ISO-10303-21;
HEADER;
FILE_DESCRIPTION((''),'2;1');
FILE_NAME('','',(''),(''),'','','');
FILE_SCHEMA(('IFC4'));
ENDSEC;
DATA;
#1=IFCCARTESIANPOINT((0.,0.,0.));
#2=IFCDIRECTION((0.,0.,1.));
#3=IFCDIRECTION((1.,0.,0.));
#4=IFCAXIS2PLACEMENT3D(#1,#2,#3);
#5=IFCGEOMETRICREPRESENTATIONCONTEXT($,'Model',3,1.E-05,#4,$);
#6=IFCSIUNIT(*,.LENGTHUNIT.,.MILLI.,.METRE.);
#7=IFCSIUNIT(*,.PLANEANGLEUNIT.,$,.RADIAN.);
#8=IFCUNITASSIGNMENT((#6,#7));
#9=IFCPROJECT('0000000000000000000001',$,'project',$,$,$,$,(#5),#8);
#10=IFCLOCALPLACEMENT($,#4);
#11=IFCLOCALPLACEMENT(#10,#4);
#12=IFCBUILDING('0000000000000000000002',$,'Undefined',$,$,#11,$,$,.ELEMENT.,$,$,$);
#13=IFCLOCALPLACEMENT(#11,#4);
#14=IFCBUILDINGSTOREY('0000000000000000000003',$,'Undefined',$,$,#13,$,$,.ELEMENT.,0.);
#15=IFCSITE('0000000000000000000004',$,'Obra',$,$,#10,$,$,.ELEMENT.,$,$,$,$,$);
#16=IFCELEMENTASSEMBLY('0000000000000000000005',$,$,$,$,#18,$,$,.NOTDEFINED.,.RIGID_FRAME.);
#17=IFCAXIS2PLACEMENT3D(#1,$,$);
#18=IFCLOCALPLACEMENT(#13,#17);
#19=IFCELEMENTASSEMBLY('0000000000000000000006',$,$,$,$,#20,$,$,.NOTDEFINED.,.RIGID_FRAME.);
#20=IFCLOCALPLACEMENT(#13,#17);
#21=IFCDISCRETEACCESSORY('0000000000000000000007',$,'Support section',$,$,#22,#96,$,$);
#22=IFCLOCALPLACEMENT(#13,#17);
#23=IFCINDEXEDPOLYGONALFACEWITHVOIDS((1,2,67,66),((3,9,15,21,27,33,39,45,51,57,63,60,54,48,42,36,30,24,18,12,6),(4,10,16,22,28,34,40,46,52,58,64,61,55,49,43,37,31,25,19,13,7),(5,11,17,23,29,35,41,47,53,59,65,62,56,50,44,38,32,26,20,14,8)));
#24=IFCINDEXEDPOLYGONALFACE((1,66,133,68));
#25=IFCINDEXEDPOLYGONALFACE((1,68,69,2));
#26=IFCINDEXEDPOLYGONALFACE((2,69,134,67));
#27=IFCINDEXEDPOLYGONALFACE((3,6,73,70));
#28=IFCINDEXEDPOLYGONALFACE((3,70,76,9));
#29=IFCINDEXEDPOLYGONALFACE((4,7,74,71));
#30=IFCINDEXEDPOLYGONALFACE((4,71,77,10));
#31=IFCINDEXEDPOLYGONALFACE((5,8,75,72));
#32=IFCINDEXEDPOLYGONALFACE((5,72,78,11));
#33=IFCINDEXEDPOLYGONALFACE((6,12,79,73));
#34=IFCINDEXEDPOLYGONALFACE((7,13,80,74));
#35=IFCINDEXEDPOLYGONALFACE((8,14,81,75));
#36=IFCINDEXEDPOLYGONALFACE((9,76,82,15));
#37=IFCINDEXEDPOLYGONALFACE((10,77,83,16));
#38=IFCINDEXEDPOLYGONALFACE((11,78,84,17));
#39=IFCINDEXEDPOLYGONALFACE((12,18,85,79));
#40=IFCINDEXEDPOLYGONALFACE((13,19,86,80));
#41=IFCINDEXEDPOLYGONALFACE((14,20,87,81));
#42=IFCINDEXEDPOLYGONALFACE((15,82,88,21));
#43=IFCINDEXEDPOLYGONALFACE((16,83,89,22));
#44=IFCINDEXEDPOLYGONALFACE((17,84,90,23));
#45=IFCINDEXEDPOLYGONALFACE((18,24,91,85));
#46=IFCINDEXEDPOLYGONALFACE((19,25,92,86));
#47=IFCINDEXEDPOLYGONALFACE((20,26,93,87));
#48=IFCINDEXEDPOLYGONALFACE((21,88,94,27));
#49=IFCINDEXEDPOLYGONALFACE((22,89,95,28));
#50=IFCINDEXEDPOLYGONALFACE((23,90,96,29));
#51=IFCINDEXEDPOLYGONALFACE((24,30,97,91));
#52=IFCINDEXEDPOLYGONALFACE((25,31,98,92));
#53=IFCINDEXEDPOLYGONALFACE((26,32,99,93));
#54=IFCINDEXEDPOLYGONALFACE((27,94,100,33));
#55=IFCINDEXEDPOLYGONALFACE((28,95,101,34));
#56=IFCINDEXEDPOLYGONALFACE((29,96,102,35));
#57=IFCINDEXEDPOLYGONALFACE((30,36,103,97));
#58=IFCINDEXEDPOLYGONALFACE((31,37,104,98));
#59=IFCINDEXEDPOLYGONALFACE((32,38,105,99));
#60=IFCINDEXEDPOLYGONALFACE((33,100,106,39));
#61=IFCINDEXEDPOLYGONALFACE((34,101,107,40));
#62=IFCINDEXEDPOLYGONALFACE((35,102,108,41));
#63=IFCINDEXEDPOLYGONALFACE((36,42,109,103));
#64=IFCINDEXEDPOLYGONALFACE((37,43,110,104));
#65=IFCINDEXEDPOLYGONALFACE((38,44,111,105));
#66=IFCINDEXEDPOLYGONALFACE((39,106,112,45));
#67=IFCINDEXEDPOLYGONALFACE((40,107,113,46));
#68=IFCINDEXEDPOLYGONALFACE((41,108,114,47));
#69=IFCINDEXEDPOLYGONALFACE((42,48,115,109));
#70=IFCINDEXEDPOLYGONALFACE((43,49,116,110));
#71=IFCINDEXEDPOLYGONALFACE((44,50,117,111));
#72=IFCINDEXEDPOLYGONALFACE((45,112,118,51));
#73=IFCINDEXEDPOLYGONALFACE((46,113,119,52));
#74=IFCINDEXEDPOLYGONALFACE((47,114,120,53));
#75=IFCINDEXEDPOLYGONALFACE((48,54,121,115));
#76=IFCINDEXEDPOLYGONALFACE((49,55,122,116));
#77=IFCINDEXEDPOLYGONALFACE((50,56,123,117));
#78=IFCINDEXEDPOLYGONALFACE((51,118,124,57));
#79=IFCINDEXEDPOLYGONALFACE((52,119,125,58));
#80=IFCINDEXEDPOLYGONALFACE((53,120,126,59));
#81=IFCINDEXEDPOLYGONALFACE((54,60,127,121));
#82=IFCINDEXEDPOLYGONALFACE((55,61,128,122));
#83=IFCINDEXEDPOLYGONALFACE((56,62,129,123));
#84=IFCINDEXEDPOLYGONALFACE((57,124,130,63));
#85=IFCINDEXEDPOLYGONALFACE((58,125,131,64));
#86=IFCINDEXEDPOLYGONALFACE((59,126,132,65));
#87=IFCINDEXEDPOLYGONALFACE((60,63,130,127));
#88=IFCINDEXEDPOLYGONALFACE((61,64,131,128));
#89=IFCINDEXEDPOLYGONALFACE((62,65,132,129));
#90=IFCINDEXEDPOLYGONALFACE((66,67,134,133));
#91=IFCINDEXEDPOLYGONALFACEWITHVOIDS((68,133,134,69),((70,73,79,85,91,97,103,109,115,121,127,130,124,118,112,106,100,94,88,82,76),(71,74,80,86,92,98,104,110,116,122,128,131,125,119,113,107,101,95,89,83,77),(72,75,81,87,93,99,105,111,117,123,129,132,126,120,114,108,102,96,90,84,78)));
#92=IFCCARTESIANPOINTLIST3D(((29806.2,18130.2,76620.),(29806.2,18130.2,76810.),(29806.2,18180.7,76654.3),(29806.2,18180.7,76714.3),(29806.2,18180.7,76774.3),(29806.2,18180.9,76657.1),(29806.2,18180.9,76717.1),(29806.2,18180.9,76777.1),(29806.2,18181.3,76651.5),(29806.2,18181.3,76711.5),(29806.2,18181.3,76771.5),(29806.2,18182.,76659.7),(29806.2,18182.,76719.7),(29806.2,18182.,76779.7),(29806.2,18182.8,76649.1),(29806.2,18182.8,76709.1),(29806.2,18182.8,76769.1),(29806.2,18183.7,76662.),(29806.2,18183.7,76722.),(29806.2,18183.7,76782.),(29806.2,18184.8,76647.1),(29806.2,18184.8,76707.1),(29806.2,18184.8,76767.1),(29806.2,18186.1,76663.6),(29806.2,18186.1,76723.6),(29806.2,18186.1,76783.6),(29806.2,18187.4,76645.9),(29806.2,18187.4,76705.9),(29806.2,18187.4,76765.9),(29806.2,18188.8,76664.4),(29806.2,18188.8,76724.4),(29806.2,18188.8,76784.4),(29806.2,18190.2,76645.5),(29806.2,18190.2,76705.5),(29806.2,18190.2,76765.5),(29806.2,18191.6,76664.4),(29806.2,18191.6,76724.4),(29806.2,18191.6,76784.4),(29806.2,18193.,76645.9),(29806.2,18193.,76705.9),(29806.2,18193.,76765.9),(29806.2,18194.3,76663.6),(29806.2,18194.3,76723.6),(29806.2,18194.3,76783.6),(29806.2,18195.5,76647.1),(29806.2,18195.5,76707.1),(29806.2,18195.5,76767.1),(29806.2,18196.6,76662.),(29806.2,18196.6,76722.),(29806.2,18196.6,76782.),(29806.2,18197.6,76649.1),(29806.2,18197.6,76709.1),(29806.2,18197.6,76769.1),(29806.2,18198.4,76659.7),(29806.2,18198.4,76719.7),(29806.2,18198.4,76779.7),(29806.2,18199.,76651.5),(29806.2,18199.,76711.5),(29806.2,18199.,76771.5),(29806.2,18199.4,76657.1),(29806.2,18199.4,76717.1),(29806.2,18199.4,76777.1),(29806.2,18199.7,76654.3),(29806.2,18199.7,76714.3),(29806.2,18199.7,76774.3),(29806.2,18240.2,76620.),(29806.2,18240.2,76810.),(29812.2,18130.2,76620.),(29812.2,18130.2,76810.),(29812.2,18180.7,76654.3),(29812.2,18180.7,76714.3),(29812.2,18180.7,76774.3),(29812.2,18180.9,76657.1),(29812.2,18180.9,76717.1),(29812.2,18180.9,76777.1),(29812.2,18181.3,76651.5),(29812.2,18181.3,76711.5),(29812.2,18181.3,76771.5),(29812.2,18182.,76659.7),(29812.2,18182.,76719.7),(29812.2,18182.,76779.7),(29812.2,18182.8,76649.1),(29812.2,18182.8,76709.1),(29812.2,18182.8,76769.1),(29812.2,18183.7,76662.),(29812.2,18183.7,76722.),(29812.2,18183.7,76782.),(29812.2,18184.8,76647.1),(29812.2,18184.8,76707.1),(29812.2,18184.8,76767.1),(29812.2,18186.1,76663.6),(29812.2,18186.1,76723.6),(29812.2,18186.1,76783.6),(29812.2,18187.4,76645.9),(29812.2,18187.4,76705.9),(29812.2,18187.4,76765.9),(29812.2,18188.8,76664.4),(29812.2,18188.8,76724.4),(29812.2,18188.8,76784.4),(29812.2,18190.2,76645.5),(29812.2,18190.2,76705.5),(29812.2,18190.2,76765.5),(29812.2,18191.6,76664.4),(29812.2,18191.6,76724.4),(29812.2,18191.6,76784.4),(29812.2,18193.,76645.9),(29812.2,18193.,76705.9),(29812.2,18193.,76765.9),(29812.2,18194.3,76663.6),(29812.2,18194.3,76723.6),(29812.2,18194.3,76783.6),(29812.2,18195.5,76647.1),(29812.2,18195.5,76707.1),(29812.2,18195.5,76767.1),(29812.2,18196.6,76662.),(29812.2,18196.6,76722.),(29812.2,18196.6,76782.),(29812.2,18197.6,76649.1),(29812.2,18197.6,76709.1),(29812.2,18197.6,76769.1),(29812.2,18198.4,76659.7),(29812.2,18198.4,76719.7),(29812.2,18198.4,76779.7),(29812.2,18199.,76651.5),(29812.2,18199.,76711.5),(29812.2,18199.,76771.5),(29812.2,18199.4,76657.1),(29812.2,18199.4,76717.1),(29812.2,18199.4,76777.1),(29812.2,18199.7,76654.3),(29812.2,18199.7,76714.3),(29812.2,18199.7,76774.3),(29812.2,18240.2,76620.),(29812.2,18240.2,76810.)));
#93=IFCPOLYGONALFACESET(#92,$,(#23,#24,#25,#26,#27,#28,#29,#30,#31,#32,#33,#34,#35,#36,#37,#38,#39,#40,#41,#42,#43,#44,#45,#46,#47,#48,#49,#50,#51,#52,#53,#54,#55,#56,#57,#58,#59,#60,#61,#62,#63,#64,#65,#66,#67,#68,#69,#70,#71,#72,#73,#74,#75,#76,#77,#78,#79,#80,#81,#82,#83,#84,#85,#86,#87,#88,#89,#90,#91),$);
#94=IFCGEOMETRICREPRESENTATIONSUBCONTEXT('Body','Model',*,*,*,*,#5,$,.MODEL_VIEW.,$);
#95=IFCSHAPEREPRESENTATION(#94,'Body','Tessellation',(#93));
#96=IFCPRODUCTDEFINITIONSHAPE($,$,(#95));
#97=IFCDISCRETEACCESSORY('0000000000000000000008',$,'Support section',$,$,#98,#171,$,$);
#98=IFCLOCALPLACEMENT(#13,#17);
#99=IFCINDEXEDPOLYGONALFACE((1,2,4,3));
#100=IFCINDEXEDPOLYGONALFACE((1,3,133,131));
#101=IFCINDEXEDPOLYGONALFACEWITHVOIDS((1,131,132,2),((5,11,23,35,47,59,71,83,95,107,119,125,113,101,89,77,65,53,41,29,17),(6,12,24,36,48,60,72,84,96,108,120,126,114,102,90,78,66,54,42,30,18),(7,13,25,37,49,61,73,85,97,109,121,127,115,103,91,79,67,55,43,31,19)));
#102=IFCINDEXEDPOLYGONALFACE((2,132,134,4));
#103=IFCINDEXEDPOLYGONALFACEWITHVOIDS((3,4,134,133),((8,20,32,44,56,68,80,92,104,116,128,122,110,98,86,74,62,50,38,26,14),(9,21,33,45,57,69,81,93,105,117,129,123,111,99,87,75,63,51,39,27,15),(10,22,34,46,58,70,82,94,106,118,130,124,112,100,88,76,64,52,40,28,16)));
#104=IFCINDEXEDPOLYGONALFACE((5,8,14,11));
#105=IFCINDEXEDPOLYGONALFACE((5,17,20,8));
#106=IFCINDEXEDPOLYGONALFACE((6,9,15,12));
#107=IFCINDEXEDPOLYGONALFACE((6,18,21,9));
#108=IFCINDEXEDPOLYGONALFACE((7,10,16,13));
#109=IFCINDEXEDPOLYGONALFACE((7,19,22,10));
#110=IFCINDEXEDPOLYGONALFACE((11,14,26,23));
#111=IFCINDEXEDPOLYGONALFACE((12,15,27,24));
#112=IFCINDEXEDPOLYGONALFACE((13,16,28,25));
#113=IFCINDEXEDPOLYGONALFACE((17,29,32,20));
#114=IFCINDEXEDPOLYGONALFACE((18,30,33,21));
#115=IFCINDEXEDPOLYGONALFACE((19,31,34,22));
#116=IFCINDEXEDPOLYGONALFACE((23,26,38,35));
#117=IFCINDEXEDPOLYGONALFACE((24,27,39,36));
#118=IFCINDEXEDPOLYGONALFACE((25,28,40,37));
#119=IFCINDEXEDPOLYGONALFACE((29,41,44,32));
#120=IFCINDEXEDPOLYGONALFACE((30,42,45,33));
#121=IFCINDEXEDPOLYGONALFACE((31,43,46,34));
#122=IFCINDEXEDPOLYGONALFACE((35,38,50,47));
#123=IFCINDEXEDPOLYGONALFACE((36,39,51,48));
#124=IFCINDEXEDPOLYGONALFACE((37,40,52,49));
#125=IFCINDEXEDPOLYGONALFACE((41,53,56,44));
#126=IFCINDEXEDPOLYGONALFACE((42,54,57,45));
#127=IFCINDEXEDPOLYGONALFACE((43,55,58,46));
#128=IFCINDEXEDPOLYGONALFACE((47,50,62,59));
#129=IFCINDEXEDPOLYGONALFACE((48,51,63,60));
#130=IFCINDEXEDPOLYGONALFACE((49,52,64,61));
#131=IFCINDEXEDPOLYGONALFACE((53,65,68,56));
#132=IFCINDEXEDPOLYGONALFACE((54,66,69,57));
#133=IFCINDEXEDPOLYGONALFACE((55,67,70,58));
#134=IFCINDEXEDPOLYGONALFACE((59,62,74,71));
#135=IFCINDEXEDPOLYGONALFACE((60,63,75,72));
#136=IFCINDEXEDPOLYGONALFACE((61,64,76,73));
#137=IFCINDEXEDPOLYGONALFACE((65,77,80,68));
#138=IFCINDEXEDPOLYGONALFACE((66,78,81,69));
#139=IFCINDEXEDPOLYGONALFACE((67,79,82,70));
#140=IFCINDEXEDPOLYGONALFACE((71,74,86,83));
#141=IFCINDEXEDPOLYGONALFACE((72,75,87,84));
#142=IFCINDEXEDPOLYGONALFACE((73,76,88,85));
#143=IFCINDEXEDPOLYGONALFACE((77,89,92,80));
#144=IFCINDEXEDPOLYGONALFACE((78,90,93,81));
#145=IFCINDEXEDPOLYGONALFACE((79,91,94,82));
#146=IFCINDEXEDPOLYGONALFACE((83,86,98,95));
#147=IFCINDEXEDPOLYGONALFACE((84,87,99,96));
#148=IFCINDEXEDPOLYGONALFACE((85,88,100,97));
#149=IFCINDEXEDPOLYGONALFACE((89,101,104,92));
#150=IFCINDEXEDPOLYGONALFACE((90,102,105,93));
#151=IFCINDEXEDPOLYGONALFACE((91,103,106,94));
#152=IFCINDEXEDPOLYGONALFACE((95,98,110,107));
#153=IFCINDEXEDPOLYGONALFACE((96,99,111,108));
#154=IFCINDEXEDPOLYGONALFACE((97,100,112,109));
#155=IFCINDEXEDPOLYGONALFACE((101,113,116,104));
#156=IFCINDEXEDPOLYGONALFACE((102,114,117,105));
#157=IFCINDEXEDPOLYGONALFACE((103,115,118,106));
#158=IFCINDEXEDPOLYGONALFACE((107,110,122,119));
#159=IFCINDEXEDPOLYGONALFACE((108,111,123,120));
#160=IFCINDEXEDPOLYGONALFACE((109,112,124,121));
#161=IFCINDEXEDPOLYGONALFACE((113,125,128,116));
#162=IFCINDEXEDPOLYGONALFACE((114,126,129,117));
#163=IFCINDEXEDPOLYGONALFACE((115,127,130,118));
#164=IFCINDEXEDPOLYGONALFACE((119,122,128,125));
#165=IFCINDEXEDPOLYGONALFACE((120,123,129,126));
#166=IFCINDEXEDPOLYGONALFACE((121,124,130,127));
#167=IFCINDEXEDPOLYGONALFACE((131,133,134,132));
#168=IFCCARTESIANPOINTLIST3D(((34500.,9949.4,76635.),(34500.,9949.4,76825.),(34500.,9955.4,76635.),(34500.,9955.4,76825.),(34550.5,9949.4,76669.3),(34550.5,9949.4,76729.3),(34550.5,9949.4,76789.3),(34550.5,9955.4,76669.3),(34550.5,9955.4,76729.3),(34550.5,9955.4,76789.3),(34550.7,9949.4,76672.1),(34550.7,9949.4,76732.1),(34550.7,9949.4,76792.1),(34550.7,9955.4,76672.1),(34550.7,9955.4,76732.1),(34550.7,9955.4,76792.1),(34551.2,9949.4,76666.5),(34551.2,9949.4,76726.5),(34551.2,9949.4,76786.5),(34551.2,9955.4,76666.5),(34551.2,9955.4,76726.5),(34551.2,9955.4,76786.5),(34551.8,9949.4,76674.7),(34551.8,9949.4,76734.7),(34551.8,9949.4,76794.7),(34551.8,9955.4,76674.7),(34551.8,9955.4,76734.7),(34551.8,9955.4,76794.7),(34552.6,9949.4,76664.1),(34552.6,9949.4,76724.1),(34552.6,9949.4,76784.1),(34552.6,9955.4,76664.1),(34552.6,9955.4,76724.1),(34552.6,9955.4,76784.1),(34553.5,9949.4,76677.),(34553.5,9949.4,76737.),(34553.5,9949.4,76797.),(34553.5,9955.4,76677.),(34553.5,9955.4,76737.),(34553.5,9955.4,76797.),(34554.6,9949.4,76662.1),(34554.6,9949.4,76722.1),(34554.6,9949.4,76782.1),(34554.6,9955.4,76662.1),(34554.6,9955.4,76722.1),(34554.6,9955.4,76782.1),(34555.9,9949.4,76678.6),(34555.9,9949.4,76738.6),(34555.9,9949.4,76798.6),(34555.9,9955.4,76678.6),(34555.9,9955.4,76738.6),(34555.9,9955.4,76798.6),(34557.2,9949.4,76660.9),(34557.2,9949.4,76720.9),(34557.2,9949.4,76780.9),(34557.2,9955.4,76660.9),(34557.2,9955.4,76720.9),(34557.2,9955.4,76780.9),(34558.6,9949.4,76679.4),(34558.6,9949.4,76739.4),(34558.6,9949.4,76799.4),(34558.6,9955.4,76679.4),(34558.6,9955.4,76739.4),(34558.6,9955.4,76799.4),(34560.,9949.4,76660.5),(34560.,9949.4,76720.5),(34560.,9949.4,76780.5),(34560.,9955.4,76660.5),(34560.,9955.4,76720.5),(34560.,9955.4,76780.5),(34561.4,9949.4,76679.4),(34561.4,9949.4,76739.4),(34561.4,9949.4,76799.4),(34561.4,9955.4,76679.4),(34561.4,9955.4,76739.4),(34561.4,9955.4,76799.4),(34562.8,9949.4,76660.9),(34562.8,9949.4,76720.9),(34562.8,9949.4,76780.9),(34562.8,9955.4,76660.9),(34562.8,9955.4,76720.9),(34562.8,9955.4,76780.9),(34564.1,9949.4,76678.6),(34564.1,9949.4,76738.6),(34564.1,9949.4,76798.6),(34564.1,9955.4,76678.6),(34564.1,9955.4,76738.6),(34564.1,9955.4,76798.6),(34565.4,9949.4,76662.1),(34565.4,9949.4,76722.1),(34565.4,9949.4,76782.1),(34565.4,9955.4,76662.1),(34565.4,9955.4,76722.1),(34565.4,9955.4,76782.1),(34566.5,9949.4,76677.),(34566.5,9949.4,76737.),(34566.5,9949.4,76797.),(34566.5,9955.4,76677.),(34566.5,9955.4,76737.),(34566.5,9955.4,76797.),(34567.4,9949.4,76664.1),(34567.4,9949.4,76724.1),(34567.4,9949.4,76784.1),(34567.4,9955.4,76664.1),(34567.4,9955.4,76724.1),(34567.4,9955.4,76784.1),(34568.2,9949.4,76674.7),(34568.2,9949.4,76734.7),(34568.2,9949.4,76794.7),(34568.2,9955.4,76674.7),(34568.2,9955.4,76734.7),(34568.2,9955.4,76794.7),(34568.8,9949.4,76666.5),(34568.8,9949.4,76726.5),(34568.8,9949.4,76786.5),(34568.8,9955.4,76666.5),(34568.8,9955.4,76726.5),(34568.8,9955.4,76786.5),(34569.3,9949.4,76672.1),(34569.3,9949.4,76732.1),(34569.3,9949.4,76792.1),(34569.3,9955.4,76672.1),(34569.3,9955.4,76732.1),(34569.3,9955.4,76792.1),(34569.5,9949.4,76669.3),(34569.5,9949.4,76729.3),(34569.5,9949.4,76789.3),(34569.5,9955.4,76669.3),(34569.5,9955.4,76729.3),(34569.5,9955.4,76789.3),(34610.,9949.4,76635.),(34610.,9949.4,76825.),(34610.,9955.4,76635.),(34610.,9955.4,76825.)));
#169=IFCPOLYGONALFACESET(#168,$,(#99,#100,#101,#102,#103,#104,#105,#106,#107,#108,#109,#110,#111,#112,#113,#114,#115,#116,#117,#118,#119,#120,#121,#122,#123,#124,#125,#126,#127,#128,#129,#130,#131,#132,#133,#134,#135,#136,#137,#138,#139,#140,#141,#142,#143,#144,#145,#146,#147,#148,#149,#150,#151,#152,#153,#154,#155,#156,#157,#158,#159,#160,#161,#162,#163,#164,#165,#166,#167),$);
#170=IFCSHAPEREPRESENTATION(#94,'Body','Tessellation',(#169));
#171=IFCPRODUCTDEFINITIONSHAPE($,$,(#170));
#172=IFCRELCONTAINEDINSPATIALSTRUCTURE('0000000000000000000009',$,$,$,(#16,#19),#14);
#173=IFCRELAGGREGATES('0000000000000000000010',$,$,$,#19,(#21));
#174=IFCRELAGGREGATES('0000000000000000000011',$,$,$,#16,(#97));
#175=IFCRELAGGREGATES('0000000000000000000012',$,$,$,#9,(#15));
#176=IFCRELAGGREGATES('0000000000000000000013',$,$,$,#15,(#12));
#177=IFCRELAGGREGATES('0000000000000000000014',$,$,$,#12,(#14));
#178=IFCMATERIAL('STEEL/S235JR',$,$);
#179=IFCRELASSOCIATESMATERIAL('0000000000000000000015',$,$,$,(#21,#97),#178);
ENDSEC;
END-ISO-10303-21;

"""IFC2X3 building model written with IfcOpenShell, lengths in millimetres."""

from ifc_helpers import new_model, si_unit, frame, origin_with_axes, origin_2d_with_axis, place, context, subcontext, project, spatial, rectangle, circle, extrude, source, transform, mapped, material, element, aggregate, save


model = new_model("IFC2X3")

# Units and contexts
model_context = context("Model", 3, precision=1e-05, world=origin_with_axes())
body_context = subcontext(model_context, "Body", "Model", "MODEL_VIEW")
ifc_project = project(units=[si_unit("LENGTHUNIT", "METRE", prefix="MILLI"), si_unit("PLANEANGLEUNIT", "RADIAN")], contexts=[model_context])

# Site, building, storey
site_placement = place(None, origin_with_axes())
site = spatial("IfcSite", under=ifc_project, at=site_placement, Name="Obra", CompositionType="ELEMENT")
building_placement = place(site_placement, origin_with_axes())
building = spatial("IfcBuilding", under=site, at=building_placement, Name="Undefined", CompositionType="ELEMENT")
storey_placement = place(building_placement, origin_with_axes())
storey = spatial("IfcBuildingStorey", under=building, at=storey_placement, Name="Undefined", CompositionType="ELEMENT", Elevation=0.0)

# Element assembly
ifc_material = material(Name="STEEL/S235JR")
assembly_1_placement = place(storey_placement, origin_with_axes())
assembly_1 = element("IfcElementAssembly", 1, at=assembly_1_placement, inside=storey, AssemblyPlace="NOTDEFINED", PredefinedType="RIGID_FRAME")

# Shared definitions
shared_shape_1 = source(origin_with_axes(), body_context, "Body", "SweptSolid", [
    extrude(circle(Radius=9.5, at=origin_2d_with_axis()), frame((0.0, -9.2, 0.0), z_axis=(0.0, 1.0, 0.0), x_axis=(1.0, 0.0, 0.0)), (0.0, 0.0, 1.0), 6.2),
])

# Element assembly, discrete accessory, opening
assembly_2_placement = place(storey_placement, origin_with_axes())
assembly_2 = element("IfcElementAssembly", 2, at=assembly_2_placement, inside=storey, AssemblyPlace="NOTDEFINED", PredefinedType="RIGID_FRAME")
discrete_accessory_1_placement = place(assembly_2_placement, frame((29809.2, 18185.2, 76620.0), z_axis=(0.0, 0.0, 1.0), x_axis=(0.000002, -1.0, 0.0)))
discrete_accessory_1 = element("IfcDiscreteAccessory", 3, at=discrete_accessory_1_placement, material=ifc_material, Name="Support section", context=body_context, shape_type="SweptSolid", body=[
    extrude(rectangle(XDim=6.0, YDim=110.0, at=origin_2d_with_axis()), frame((0.0, 0.0, 190.0), z_axis=(0.0, 0.0, -1.0), x_axis=(0.0, 1.0, 0.0)), (0.0, 0.0, 1.0), 190.0),
])
opening_1_placement = place(assembly_2_placement, frame((29803.1, 18140.2, 76835.0), z_axis=(-0.000002, 1.0, 0.0), x_axis=(0.0, 0.0, -1.0)))
element("IfcOpeningElement", 4, at=opening_1_placement, cuts=discrete_accessory_1, ObjectType="Opening", context=body_context, shape_type="MappedRepresentation", body=[
    mapped(shared_shape_1, transform((60.0, 0.0, 50.0))),
    mapped(shared_shape_1, transform((120.0, 0.0, 50.0))),
    mapped(shared_shape_1, transform((180.0, 0.0, 50.0))),
])
aggregate(assembly_2, [discrete_accessory_1])

# Discrete accessory, opening
discrete_accessory_2_placement = place(assembly_1_placement, frame((34555.0, 9952.4, 76635.0), z_axis=(0.0, 0.0, 1.0), x_axis=(-1.0, 0.0, 0.0)))
discrete_accessory_2 = element("IfcDiscreteAccessory", 5, at=discrete_accessory_2_placement, material=ifc_material, Name="Support section", context=body_context, shape_type="SweptSolid", body=[
    extrude(rectangle(XDim=6.0, YDim=110.0, at=origin_2d_with_axis()), frame((0.0, 0.0, 190.0), z_axis=(0.0, 0.0, -1.0), x_axis=(0.0, 1.0, 0.0)), (0.0, 0.0, 1.0), 190.0),
])
opening_2_placement = place(assembly_1_placement, frame((34510.0, 9958.5, 76850.0), z_axis=(1.0, 0.0, 0.0), x_axis=(0.0, 0.0, -1.0)))
element("IfcOpeningElement", 6, at=opening_2_placement, cuts=discrete_accessory_2, ObjectType="Opening", context=body_context, shape_type="MappedRepresentation", body=[
    mapped(shared_shape_1, transform((60.0, 0.0, 50.0))),
    mapped(shared_shape_1, transform((120.0, 0.0, 50.0))),
    mapped(shared_shape_1, transform((180.0, 0.0, 50.0))),
])
aggregate(assembly_1, [discrete_accessory_2])

save(model, "model.ifc")
